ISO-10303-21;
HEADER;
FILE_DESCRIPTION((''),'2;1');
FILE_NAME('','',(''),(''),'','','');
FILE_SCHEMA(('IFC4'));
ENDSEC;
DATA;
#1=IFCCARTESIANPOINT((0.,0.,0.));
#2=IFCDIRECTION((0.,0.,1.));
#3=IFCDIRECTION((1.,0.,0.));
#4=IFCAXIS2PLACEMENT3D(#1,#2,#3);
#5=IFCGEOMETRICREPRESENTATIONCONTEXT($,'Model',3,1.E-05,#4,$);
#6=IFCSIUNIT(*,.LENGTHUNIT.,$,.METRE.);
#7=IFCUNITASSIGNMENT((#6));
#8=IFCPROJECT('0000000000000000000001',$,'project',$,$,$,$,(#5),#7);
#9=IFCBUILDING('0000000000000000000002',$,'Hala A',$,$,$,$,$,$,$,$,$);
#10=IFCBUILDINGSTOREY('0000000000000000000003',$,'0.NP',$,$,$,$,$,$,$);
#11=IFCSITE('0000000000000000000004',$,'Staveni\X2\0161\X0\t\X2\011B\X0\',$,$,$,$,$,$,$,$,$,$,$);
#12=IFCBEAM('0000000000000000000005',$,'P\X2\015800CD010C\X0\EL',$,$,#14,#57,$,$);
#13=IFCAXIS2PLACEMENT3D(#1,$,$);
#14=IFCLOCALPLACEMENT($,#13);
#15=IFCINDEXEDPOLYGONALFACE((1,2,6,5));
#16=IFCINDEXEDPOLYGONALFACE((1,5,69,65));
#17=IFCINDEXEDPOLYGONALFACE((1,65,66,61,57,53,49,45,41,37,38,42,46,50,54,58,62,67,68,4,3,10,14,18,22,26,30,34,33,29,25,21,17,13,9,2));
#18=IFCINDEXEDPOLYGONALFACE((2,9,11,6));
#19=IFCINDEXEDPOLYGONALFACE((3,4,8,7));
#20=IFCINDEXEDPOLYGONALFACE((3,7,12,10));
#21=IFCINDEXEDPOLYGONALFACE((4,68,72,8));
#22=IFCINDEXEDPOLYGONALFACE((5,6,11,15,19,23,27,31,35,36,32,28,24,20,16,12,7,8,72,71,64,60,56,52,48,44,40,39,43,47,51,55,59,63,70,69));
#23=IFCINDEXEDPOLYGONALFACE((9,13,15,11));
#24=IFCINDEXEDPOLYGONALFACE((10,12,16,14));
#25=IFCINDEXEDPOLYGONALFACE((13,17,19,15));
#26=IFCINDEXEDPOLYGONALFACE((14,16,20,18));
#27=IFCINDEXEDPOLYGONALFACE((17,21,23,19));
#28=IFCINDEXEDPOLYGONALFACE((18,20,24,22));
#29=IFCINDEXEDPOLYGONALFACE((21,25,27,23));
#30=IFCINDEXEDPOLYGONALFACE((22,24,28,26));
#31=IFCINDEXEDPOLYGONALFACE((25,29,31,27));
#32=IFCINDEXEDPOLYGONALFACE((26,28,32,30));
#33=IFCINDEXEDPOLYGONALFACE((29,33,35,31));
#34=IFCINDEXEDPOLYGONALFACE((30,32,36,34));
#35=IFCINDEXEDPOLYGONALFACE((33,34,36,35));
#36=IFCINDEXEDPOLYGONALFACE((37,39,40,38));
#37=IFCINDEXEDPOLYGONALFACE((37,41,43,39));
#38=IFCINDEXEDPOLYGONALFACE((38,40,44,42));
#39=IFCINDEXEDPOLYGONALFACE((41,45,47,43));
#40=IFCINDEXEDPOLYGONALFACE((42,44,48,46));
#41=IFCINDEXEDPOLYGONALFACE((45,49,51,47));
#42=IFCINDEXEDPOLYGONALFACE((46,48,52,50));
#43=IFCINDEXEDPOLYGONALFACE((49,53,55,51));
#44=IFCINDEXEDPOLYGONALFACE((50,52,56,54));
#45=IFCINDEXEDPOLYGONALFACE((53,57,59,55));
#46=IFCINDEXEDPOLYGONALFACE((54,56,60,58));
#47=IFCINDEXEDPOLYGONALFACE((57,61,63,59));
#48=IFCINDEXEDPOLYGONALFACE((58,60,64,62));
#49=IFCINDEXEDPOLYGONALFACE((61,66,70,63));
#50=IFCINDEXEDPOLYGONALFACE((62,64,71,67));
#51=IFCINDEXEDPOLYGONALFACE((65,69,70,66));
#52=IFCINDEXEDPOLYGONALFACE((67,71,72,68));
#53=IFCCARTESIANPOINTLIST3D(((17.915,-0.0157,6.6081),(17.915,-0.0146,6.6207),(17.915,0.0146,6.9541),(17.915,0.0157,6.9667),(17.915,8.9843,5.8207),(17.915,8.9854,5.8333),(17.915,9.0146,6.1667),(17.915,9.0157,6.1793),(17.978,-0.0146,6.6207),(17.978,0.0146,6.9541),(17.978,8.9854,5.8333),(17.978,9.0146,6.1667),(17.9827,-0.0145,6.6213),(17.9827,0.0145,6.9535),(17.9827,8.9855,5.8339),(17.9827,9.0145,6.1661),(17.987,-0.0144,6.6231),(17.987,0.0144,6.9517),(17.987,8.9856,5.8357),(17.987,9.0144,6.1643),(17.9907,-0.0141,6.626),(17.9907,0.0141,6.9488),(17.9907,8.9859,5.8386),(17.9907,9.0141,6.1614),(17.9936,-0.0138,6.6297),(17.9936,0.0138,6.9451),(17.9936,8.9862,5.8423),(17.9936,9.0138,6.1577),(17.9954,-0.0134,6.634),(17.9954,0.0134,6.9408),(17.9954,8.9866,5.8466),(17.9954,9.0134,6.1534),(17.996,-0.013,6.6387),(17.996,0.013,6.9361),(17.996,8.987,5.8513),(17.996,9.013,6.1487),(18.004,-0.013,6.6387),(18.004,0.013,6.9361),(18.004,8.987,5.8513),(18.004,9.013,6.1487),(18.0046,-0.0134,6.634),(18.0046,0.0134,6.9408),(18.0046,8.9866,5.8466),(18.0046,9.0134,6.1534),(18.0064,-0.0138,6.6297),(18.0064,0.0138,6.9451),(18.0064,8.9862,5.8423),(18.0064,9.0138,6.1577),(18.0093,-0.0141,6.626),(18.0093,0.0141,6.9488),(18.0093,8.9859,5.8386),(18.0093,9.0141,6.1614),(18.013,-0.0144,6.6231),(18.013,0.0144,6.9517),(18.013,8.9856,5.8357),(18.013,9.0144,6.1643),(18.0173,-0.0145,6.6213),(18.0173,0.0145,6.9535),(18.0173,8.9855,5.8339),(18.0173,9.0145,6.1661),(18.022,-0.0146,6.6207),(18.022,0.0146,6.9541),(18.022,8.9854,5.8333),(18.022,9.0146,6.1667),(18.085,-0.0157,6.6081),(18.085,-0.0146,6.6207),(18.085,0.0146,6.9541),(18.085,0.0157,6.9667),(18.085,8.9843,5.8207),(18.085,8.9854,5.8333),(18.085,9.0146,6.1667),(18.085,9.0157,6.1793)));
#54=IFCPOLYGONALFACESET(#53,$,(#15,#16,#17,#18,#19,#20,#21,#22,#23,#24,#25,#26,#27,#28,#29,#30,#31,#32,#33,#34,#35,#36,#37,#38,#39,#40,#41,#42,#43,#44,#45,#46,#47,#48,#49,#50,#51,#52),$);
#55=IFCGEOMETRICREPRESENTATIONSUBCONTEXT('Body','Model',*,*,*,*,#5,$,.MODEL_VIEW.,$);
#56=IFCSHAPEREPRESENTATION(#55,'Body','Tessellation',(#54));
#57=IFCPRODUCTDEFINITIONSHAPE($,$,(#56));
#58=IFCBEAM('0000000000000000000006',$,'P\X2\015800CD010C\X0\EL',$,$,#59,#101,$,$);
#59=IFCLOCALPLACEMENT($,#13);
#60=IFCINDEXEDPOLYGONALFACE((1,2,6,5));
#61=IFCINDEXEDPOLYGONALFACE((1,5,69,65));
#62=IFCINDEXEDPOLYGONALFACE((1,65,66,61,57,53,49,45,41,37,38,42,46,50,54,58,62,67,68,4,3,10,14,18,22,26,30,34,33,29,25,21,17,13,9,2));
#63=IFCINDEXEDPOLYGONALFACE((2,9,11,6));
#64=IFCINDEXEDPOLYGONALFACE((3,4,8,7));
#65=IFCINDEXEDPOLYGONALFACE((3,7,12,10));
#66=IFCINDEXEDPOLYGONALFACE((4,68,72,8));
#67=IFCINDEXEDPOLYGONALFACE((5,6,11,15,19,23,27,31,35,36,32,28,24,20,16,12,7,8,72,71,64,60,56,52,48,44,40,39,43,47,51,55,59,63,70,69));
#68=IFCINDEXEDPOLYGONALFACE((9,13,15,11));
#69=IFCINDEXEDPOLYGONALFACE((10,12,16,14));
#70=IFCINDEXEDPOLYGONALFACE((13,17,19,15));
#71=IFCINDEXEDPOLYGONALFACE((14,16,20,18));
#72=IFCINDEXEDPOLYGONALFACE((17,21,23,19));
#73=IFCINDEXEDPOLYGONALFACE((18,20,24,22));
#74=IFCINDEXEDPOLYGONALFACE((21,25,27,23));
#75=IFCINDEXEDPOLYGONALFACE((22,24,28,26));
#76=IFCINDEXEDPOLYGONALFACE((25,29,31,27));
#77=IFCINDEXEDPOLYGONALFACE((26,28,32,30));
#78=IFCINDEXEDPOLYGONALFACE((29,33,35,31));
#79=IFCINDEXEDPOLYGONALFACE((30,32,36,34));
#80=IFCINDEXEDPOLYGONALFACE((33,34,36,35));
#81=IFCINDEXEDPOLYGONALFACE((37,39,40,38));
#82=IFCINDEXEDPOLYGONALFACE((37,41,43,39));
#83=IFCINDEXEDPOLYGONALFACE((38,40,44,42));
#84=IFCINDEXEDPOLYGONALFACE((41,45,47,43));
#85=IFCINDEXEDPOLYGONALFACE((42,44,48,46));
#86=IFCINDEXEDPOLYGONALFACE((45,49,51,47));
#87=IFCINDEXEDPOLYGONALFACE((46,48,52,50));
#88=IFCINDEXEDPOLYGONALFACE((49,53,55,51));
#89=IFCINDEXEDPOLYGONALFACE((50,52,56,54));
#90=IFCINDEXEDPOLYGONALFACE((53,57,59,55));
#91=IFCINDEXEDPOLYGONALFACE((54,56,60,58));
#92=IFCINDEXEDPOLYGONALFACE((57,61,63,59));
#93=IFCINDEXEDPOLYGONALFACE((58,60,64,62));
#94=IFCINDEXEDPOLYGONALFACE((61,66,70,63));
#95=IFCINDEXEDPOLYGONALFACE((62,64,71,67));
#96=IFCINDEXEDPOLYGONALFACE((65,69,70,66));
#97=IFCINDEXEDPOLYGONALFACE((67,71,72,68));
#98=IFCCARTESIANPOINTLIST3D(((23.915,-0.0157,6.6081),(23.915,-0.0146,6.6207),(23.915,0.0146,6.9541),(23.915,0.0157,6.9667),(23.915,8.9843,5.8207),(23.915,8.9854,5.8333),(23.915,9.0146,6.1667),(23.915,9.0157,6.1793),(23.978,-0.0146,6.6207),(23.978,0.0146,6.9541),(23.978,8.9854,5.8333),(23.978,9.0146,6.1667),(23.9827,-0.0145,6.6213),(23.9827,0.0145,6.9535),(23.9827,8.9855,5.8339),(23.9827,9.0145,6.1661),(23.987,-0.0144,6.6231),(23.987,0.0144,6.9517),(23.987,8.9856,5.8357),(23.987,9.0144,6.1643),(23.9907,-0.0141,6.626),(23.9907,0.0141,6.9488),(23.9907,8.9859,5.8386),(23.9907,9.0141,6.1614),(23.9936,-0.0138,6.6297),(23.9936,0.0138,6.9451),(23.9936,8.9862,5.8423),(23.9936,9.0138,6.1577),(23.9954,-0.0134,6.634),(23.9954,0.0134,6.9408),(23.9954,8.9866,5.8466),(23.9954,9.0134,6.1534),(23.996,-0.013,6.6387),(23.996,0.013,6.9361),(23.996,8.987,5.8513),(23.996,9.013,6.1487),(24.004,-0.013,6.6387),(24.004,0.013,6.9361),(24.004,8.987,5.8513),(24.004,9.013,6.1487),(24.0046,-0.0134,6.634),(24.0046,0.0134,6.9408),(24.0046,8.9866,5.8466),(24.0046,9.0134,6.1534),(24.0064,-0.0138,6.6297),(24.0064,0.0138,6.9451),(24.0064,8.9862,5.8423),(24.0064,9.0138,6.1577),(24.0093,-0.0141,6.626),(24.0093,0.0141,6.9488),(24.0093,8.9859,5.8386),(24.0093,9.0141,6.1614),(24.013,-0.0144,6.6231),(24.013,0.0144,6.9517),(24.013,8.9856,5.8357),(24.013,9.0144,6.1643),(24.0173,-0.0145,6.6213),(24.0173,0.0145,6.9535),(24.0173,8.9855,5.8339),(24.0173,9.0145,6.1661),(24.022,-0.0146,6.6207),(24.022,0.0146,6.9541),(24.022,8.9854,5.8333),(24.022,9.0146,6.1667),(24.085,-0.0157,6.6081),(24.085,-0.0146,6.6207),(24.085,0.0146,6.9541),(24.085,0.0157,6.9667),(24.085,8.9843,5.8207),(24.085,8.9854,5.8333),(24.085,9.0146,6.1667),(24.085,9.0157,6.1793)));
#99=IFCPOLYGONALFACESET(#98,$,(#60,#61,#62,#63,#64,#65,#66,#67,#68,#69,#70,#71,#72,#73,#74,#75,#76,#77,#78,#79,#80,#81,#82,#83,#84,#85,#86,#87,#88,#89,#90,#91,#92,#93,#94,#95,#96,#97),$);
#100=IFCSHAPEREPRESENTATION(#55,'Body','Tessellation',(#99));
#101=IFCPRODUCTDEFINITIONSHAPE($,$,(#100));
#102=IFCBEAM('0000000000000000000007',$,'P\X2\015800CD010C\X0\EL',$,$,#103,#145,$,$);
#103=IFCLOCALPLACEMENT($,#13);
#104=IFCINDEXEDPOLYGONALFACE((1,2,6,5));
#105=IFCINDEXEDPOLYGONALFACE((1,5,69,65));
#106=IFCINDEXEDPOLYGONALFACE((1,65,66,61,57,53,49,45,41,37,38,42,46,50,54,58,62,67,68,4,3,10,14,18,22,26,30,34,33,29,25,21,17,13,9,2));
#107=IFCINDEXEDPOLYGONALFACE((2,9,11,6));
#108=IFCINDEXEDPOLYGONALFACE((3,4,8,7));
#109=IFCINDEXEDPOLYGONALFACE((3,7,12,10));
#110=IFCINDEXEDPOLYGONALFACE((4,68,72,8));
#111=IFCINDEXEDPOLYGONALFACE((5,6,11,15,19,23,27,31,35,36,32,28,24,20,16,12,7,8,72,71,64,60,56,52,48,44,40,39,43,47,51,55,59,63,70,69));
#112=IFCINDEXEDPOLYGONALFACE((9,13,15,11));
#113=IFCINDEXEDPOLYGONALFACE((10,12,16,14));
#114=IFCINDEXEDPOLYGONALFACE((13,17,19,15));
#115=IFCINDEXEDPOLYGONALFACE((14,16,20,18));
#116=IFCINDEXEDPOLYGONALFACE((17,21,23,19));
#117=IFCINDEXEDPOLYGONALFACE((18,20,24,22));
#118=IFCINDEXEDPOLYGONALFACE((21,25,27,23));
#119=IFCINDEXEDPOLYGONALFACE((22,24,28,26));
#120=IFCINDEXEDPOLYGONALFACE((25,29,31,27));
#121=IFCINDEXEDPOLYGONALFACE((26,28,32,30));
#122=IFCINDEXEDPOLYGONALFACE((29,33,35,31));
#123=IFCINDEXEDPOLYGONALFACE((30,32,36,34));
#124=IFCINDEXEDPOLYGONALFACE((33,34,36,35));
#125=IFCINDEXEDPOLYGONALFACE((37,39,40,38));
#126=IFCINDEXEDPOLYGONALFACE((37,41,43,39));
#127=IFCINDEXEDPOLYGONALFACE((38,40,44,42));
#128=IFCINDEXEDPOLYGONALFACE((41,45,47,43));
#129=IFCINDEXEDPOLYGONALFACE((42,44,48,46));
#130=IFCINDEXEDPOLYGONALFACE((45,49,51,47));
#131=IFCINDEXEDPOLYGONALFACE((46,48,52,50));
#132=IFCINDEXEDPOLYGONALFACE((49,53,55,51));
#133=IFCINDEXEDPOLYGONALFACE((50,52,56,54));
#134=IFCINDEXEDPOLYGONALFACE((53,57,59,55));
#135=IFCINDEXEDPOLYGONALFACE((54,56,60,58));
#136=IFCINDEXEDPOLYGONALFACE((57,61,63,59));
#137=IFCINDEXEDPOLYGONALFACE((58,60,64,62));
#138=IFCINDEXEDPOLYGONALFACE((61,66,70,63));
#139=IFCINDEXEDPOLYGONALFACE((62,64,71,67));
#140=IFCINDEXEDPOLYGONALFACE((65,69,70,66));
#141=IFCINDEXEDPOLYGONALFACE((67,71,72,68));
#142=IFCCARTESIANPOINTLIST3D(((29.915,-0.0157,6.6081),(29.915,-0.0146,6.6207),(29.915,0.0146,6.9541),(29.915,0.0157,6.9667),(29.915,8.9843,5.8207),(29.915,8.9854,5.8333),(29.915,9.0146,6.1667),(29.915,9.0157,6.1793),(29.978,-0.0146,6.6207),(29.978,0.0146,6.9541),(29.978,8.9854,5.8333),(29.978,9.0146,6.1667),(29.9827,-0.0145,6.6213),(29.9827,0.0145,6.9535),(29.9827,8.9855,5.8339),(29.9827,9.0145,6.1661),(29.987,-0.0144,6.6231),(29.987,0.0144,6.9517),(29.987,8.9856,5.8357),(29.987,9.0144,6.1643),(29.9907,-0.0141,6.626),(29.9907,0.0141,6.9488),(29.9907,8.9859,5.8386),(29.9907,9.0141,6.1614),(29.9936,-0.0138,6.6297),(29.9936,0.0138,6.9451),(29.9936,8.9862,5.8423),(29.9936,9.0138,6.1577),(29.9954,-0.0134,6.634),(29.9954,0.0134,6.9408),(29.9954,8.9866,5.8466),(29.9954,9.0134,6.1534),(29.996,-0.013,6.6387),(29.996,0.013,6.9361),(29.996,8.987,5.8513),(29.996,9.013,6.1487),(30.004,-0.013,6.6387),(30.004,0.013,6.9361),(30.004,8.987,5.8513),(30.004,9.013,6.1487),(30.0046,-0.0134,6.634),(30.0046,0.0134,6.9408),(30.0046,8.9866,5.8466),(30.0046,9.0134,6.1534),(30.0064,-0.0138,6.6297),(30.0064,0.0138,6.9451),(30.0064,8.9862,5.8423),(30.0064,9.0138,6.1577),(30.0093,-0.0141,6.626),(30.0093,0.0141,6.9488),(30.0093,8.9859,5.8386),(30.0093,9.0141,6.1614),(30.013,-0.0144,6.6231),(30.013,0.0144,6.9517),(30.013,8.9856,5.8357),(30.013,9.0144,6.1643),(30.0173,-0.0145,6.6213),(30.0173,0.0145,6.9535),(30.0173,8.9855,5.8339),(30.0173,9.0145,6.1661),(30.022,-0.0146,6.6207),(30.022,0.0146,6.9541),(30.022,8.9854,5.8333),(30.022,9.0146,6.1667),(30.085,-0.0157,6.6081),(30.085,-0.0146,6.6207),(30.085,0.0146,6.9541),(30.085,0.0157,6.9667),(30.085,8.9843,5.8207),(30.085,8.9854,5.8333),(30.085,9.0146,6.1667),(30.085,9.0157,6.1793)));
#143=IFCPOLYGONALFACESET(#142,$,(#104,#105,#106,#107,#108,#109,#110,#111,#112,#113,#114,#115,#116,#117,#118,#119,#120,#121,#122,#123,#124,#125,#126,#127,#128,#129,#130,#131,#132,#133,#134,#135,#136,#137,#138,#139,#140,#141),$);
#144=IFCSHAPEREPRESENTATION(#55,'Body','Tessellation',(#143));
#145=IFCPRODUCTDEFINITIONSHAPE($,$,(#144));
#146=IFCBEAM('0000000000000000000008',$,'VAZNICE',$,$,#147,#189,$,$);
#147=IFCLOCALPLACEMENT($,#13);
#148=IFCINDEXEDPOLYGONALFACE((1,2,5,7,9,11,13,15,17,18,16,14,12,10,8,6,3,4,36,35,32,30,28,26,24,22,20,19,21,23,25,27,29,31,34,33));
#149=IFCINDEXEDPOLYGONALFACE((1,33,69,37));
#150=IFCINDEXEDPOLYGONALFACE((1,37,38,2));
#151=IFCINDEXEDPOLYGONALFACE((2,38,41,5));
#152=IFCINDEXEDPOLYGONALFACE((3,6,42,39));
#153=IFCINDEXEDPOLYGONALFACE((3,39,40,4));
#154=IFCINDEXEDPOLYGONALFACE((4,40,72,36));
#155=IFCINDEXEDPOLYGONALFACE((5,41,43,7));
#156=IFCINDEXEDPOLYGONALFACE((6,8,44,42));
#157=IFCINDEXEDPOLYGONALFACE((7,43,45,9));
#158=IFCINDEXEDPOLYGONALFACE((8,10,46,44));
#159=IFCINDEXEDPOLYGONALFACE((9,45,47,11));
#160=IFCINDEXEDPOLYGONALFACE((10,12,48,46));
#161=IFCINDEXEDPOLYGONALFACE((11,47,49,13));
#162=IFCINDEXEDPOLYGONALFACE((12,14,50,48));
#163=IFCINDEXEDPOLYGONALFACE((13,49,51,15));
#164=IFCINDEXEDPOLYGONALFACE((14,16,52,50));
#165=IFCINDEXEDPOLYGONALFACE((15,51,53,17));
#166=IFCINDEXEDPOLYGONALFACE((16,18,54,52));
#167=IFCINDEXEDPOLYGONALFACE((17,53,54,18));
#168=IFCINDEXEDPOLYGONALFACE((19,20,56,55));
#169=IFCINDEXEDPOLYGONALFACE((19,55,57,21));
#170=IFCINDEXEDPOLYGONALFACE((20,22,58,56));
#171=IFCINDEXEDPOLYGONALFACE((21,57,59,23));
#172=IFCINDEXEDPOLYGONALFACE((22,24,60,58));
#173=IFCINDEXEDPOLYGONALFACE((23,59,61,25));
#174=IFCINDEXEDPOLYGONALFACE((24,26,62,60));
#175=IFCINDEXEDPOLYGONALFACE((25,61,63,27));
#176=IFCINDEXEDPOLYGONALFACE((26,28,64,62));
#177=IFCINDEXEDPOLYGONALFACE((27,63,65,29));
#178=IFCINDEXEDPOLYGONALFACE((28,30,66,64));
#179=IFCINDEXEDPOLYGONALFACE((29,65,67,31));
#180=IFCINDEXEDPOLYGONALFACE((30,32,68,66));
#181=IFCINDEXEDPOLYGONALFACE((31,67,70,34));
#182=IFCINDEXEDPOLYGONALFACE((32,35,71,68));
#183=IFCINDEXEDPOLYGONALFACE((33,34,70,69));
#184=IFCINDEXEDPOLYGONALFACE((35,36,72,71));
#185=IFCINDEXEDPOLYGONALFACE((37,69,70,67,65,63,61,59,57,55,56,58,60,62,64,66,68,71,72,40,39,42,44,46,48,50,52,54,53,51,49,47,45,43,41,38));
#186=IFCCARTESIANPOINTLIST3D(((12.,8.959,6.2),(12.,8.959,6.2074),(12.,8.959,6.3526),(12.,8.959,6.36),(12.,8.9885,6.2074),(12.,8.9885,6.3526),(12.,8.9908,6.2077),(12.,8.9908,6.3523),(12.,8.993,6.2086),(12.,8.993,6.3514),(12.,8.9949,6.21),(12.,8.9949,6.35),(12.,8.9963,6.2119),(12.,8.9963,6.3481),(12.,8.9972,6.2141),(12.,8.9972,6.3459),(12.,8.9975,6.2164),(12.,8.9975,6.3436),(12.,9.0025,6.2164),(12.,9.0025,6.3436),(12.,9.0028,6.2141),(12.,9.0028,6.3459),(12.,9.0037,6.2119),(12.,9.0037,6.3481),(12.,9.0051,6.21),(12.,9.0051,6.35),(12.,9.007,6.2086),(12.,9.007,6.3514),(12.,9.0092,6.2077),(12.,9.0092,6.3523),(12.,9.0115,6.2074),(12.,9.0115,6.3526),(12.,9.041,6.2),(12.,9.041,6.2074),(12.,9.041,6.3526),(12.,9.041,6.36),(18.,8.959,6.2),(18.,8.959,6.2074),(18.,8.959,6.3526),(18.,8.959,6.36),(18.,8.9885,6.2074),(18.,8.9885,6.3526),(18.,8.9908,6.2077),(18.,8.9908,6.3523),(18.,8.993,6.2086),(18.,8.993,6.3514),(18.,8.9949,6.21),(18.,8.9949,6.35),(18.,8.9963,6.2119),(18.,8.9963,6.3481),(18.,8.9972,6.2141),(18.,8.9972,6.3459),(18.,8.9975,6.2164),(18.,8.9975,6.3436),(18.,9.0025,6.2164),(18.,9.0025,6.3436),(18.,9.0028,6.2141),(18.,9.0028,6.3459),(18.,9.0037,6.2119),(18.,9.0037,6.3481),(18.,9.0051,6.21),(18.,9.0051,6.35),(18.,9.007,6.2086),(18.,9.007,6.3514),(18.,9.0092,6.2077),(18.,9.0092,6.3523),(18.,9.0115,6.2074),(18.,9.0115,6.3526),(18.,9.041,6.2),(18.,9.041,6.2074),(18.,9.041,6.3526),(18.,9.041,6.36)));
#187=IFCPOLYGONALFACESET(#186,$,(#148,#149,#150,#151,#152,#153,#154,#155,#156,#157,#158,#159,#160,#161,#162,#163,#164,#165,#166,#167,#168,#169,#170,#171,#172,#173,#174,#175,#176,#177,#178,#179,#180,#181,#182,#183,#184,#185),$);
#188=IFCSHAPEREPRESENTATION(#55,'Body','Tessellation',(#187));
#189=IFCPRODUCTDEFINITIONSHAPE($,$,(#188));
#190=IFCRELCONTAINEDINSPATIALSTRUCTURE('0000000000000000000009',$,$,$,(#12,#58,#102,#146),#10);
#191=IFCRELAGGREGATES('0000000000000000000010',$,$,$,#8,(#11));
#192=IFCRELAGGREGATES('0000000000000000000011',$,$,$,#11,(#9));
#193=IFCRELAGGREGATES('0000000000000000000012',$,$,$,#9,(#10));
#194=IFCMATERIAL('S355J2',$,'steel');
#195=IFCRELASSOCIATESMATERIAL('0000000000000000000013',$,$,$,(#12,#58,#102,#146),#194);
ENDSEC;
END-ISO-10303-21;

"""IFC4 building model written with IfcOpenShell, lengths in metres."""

from ifc_helpers import new_model, si_unit, frame, origin_with_axes, place, context, subcontext, project, spatial, i_section, extrude, material, element, save


model = new_model("IFC4")

# Units and contexts
model_context = context("Model", 3, precision=1e-05, world=origin_with_axes())
body_context = subcontext(model_context, "Body", "Model", "MODEL_VIEW")
ifc_project = project(units=[si_unit("LENGTHUNIT", "METRE")], contexts=[model_context])

# Site, building, storey
site = spatial("IfcSite", under=ifc_project, Name="Staveniště")
building = spatial("IfcBuilding", under=site, Name="Hala A")
storey = spatial("IfcBuildingStorey", under=building, Name="0.NP")

# Shared definitions
ifc_material_1 = material(Name="S355J2", Category="steel")

# Beams
for number, where, z_axis, x_axis, name in (
    (1, (18.0, 9.0, 6.0), (0.0, -0.996195, 0.087156), (1.0, 0.0, 0.0), "PŘÍČEL"),
    (2, (24.0, 9.0, 6.0), (0.0, -0.996195, 0.087156), (1.0, 0.0, 0.0), "PŘÍČEL"),
    (3, (30.0, 9.0, 6.0), (0.0, -0.996195, 0.087156), (1.0, 0.0, 0.0), "PŘÍČEL"),
):
    element("IfcBeam", number, at=place(None, frame(where, z_axis=z_axis, x_axis=x_axis)), inside=storey, material=ifc_material_1, Name=name, context=body_context, shape_type="SweptSolid", body=[
        extrude(i_section(OverallWidth=0.17, OverallDepth=0.36, WebThickness=0.008, FlangeThickness=0.0127, FilletRadius=0.018), origin_with_axes(), (0.0, 0.0, 1.0), 9.0344),
    ])
for number, where, z_axis, x_axis, name in (
    (4, (12.0, 9.0, 6.28), (1.0, 0.0, 0.0), (0.0, 1.0, 0.0), "VAZNICE"),
):
    element("IfcBeam", number, at=place(None, frame(where, z_axis=z_axis, x_axis=x_axis)), inside=storey, material=ifc_material_1, Name=name, context=body_context, shape_type="SweptSolid", body=[
        extrude(i_section(OverallWidth=0.082, OverallDepth=0.16, WebThickness=0.005, FlangeThickness=0.0074, FilletRadius=0.009), origin_with_axes(), (0.0, 0.0, 1.0), 6.0),
    ])

save(model, "model.ifc")
